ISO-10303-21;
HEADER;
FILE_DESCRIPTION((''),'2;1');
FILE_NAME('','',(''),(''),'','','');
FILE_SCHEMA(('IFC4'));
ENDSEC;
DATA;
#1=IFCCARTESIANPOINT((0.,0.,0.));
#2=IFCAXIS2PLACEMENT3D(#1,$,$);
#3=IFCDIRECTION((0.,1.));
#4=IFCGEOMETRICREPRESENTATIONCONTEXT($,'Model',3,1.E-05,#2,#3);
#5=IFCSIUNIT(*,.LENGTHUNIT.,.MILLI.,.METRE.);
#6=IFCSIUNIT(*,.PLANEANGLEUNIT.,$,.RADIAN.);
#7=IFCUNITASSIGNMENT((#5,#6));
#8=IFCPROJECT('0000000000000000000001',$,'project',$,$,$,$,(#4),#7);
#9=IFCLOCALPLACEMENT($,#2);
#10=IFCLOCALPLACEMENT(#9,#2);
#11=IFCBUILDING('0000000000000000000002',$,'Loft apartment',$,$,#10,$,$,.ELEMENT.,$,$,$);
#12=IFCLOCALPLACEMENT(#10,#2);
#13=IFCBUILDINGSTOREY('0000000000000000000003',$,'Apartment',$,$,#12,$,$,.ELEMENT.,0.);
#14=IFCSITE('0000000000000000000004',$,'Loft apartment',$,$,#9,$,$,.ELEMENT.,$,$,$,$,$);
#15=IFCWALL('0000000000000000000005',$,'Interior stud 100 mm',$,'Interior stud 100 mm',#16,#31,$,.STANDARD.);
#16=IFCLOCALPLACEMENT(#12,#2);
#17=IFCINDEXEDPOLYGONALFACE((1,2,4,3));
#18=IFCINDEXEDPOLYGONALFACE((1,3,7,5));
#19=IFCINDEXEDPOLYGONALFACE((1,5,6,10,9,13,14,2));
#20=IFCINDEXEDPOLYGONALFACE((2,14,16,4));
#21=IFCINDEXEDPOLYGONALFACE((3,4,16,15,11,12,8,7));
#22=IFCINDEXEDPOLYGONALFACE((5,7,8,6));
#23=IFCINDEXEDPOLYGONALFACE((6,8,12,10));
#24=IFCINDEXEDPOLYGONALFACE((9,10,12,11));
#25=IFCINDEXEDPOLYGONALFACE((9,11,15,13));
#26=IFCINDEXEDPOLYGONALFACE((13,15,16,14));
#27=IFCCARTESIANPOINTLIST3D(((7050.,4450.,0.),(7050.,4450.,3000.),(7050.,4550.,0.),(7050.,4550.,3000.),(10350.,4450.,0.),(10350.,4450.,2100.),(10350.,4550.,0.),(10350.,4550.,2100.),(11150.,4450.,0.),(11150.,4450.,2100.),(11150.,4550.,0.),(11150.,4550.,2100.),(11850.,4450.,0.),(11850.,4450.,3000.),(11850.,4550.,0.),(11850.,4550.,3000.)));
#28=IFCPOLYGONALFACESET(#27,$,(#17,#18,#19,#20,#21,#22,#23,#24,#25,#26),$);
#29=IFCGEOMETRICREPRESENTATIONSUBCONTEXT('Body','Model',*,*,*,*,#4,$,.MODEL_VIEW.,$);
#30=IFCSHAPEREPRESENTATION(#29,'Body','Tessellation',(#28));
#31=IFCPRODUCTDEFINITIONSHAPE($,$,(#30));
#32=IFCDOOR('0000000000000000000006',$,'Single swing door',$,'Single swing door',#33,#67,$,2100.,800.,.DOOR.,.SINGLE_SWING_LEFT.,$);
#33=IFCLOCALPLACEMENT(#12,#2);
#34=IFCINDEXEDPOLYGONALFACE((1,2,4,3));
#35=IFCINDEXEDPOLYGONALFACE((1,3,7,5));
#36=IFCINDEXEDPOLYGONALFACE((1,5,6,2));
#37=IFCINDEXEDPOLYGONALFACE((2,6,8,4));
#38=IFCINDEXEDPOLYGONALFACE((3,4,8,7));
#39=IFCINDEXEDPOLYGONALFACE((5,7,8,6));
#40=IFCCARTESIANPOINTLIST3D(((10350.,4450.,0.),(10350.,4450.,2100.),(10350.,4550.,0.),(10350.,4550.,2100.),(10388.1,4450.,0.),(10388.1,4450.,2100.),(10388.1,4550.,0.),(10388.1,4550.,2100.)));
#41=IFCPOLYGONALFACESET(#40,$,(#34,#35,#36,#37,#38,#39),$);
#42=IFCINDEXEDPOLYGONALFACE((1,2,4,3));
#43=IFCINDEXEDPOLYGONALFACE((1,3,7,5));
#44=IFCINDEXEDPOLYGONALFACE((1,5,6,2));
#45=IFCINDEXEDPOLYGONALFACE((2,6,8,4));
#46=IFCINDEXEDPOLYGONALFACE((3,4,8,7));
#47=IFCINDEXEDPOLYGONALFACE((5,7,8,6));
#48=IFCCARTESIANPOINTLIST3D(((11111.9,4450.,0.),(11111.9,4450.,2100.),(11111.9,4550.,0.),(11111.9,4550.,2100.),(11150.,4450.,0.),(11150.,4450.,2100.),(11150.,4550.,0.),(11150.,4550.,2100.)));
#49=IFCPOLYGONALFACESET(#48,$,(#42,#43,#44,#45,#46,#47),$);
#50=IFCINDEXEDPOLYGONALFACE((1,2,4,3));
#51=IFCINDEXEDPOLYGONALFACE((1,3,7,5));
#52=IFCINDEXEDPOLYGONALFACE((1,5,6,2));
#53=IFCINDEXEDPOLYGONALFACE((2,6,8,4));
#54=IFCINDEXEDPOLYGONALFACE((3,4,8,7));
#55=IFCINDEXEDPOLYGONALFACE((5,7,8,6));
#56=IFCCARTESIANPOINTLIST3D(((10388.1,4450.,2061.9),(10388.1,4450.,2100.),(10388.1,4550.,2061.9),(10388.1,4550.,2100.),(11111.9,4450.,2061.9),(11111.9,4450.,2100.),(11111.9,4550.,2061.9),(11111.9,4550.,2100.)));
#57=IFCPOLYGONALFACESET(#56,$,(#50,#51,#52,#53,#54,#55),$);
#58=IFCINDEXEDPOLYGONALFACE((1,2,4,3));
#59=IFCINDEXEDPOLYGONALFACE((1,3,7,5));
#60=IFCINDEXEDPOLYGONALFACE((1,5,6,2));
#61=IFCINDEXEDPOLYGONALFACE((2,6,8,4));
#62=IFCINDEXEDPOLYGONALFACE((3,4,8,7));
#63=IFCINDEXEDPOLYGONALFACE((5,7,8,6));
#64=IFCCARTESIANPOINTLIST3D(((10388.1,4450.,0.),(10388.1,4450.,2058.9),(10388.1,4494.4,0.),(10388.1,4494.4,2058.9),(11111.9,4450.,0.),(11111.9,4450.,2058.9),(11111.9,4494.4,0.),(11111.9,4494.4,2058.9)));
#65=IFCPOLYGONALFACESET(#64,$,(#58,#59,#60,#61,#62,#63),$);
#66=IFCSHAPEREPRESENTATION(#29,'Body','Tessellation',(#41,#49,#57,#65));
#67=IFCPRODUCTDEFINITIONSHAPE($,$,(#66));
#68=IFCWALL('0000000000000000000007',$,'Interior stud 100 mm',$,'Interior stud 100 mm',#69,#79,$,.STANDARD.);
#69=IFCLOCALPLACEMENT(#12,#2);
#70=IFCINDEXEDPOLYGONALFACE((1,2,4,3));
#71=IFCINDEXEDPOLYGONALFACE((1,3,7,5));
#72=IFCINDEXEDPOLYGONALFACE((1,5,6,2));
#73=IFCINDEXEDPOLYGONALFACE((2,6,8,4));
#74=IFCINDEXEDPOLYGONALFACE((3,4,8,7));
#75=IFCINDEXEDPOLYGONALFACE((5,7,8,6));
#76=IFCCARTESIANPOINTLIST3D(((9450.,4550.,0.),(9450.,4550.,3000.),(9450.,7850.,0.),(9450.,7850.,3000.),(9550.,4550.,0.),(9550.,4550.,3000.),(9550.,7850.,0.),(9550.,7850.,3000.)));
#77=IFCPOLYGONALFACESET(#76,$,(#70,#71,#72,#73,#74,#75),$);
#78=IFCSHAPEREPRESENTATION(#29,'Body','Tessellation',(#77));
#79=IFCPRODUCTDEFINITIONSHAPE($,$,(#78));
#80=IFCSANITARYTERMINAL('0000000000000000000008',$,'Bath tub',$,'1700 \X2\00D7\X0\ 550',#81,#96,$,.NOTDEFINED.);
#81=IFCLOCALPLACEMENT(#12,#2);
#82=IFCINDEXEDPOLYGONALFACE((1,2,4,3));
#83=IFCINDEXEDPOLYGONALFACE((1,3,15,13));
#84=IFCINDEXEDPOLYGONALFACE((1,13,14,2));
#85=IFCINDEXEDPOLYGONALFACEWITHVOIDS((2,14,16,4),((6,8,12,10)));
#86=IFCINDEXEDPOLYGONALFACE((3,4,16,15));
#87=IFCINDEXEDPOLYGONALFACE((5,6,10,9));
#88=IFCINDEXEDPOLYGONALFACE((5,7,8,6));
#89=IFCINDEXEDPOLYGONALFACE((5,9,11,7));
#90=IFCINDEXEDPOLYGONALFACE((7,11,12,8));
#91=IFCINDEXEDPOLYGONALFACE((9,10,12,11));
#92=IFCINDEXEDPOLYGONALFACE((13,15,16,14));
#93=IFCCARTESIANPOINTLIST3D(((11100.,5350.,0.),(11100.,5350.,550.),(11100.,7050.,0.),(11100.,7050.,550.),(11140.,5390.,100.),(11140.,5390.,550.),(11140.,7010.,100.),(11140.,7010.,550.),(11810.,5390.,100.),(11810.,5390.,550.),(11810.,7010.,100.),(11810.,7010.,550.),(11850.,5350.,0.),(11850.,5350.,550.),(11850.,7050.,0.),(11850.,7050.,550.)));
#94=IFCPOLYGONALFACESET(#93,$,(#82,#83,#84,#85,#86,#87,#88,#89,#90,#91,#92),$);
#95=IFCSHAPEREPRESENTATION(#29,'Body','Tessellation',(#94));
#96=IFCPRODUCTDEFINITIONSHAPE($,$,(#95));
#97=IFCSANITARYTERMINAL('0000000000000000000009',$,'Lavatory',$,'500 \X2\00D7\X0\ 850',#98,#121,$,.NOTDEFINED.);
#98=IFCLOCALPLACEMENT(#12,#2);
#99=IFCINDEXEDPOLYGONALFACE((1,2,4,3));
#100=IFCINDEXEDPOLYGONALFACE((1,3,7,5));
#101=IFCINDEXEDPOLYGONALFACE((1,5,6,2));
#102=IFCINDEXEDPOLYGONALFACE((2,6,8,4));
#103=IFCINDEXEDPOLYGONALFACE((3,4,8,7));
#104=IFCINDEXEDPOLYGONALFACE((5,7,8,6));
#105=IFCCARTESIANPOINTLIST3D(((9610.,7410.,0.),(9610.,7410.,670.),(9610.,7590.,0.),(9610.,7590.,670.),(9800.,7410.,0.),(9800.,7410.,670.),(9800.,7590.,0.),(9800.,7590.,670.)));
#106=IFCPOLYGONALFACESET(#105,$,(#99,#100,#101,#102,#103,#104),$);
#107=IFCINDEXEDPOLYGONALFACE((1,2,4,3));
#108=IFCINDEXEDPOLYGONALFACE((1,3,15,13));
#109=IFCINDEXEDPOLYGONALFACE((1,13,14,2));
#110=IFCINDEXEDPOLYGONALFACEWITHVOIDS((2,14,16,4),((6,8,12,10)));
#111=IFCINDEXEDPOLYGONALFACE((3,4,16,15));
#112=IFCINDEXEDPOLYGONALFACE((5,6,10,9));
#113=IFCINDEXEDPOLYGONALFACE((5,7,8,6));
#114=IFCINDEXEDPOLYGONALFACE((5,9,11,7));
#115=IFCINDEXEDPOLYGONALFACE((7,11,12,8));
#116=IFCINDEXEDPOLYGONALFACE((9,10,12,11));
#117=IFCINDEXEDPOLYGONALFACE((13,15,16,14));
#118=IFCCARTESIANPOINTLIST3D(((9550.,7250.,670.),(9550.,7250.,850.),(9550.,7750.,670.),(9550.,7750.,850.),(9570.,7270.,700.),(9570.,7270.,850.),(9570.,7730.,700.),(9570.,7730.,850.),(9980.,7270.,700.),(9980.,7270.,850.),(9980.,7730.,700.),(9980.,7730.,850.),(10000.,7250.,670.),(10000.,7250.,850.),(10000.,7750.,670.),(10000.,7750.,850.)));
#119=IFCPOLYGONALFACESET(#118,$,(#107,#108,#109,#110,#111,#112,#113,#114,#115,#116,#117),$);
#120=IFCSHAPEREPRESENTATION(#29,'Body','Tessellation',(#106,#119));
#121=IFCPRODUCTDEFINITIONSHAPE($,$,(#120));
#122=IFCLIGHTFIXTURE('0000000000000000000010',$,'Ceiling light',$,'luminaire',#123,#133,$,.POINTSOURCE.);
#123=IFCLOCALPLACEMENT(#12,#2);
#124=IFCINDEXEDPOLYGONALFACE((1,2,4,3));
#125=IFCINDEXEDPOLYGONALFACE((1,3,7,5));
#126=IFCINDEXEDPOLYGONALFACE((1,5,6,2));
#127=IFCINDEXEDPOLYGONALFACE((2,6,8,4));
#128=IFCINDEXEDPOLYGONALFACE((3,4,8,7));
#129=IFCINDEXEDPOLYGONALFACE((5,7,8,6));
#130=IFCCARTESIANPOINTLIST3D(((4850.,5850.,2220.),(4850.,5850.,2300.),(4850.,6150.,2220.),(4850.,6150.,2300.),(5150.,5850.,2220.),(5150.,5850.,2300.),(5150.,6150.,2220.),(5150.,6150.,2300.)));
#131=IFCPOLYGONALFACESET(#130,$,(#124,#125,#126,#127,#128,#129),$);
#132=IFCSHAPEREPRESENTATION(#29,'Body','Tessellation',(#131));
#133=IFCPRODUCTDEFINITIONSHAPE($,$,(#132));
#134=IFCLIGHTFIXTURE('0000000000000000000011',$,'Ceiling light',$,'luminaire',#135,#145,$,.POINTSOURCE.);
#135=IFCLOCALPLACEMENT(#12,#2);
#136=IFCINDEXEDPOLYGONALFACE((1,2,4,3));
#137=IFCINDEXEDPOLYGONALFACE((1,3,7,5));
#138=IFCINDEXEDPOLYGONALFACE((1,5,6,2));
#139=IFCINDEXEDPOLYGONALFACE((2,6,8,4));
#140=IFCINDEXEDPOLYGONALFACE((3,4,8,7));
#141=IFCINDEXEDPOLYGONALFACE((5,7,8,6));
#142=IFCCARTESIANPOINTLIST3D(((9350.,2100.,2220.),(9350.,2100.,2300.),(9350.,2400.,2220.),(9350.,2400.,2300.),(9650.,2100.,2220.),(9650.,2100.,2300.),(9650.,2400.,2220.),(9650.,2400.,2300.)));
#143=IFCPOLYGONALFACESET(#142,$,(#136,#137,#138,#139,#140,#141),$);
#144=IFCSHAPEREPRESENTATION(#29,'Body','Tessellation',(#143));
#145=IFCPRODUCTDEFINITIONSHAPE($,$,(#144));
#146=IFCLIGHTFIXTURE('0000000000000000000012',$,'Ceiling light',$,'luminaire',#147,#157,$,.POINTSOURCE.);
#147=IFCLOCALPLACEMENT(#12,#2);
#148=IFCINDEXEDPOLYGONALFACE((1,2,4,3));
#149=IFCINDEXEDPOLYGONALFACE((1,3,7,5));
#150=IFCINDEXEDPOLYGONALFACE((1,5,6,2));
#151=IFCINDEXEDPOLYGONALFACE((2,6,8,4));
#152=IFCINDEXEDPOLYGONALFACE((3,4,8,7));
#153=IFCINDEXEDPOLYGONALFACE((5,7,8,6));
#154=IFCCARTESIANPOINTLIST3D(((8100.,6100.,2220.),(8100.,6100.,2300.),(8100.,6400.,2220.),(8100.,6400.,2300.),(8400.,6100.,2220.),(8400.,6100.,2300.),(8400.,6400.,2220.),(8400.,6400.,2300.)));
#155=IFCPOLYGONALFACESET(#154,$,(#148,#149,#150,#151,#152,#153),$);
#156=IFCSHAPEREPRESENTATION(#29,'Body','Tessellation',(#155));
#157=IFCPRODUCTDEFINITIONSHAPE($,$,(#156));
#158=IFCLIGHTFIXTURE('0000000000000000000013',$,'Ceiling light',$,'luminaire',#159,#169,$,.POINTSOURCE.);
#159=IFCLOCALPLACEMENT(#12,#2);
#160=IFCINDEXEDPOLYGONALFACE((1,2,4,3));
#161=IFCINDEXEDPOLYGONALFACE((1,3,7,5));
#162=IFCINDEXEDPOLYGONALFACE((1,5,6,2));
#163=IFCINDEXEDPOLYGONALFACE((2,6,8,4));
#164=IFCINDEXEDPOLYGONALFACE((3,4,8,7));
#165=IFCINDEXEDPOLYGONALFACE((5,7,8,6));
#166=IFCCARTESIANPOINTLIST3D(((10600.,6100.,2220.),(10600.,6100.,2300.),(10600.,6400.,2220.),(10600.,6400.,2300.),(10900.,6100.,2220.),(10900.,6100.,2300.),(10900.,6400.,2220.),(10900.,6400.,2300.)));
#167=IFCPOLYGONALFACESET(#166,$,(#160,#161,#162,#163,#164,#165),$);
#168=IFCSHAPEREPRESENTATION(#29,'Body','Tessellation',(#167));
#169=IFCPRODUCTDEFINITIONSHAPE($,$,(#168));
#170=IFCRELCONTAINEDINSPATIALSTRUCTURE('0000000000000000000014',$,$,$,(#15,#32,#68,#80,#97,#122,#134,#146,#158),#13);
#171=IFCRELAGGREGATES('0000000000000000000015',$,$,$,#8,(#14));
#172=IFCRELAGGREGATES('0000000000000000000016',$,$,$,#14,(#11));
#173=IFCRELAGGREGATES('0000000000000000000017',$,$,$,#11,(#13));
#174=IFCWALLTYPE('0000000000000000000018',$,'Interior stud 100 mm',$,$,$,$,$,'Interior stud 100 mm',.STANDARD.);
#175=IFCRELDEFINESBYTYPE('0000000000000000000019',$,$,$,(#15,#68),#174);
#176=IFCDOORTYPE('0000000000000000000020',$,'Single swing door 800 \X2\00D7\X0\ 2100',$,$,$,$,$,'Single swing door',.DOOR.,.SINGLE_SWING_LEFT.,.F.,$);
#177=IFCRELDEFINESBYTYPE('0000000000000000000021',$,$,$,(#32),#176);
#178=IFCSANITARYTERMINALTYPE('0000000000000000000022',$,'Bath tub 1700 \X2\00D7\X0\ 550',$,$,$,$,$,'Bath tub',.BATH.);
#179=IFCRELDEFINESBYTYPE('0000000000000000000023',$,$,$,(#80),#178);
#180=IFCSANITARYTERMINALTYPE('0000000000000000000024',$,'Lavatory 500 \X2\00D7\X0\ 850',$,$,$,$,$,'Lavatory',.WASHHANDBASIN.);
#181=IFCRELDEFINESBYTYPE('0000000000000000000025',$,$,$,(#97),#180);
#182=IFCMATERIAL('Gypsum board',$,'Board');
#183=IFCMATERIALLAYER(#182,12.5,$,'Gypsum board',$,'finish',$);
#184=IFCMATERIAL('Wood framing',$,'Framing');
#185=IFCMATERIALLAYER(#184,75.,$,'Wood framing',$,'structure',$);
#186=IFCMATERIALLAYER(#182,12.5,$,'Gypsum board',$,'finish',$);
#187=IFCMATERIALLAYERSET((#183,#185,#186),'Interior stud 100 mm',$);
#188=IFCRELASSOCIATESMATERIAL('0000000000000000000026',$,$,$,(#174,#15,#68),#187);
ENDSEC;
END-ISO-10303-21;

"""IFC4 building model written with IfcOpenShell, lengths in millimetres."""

from ifc_helpers import new_model, entity, si_unit, direction, frame, origin, origin_with_axes, place, context, subcontext, project, spatial, polyline, outline, extrude, source, transform, mapped, material, layer, layer_set, layer_usage, type_object, type_shapes, element, fill, save


model = new_model("IFC4")

# Units and contexts
model_context = context("Model", 3, precision=1e-05, world=origin(), true_north=direction((0.0, 1.0)))
body_context = subcontext(model_context, "Body", "Model", "MODEL_VIEW")
ifc_project = project(units=[si_unit("LENGTHUNIT", "METRE", prefix="MILLI"), si_unit("PLANEANGLEUNIT", "RADIAN")], contexts=[model_context])

# Site, building, storey
site_placement = place(None, origin())
site = spatial("IfcSite", under=ifc_project, at=site_placement, Name="Loft apartment", CompositionType="ELEMENT")
building_placement = place(site_placement, origin())
building = spatial("IfcBuilding", under=site, at=building_placement, Name="Loft apartment", CompositionType="ELEMENT")
storey_placement = place(building_placement, origin())
storey = spatial("IfcBuildingStorey", under=building, at=storey_placement, Name="Apartment", CompositionType="ELEMENT", Elevation=0.0)

# Shared definitions
ifc_material_1 = material(Name="Gypsum board", Category="Board")
ifc_layer_1 = layer(ifc_material_1, 12.5, Name="Gypsum board", Category="finish")
ifc_material_2 = material(Name="Wood framing", Category="Framing")
ifc_layer_2 = layer(ifc_material_2, 75.0, Name="Wood framing", Category="structure")
ifc_layer_3 = layer(ifc_material_1, 12.5, Name="Gypsum board", Category="finish")
ifc_layer_set_1 = layer_set([ifc_layer_1, ifc_layer_2, ifc_layer_3], Name="Interior stud 100 mm")
wall_type_1 = type_object("IfcWallType", Name="Interior stud 100 mm", ElementType="Interior stud 100 mm", PredefinedType="STANDARD", material=ifc_layer_set_1)

# Wall, opening, door
ifc_layer_usage_1 = layer_usage(ifc_layer_set_1, "AXIS2", "NEGATIVE", 50.0)
wall_1_placement = place(storey_placement, frame((7000.0, 4500.0, 0.0), z_axis=(0.0, 0.0, 1.0), x_axis=(1.0, 0.0, 0.0)))
wall_1 = element("IfcWall", 1, at=wall_1_placement, inside=storey, type_object=wall_type_1, material=ifc_layer_usage_1, Name="Interior stud 100 mm", ObjectType="Interior stud 100 mm", PredefinedType="STANDARD", context=body_context, shape_type="SweptSolid", body=[
    extrude(outline(polyline([(50.0, -50.0), (4850.0, -50.0), (4850.0, 50.0), (50.0, 50.0), (50.0, -50.0)])), origin(), (0.0, 0.0, 1.0), 3000.0),
])
opening_1_placement = place(wall_1_placement, frame((3350.0, 0.0, 0.0), z_axis=(0.0, 0.0, 1.0), x_axis=(1.0, 0.0, 0.0)))
opening_1 = element("IfcOpeningElement", 2, at=opening_1_placement, cuts=wall_1, PredefinedType="OPENING", context=body_context, shape_type="SweptSolid", body=[
    extrude(outline(polyline([(0.0, -60.0), (800.0, -60.0), (800.0, 60.0), (0.0, 60.0), (0.0, -60.0)])), origin(), (0.0, 0.0, 1.0), 2100.0),
])
door_type_1 = type_object("IfcDoorType", Name="Single swing door 800 × 2100", ElementType="Single swing door", OperationType="SINGLE_SWING_LEFT", ParameterTakesPrecedence=False, PredefinedType="DOOR")
door_1_placement = place(opening_1_placement, origin_with_axes())
door_1 = element("IfcDoor", 3, at=door_1_placement, inside=storey, type_object=door_type_1, Name="Single swing door", ObjectType="Single swing door", OperationType="SINGLE_SWING_LEFT", OverallHeight=2100.0, OverallWidth=800.0, PredefinedType="DOOR", context=body_context, shape_type="SweptSolid", body=[
    extrude(outline(polyline([(0.0, -50.0), (38.1, -50.0), (38.1, 50.0), (0.0, 50.0), (0.0, -50.0)])), origin(), (0.0, 0.0, 1.0), 2100.0),
    extrude(outline(polyline([(761.9, -50.0), (800.0, -50.0), (800.0, 50.0), (761.9, 50.0), (761.9, -50.0)])), origin(), (0.0, 0.0, 1.0), 2100.0),
    extrude(outline(polyline([(38.1, -50.0), (761.9, -50.0), (761.9, 50.0), (38.1, 50.0), (38.1, -50.0)])), frame((0.0, 0.0, 2061.9)), (0.0, 0.0, 1.0), 38.1),
    extrude(outline(polyline([(38.1, -50.0), (761.9, -50.0), (761.9, -5.5), (38.1, -5.5), (38.1, -50.0)])), origin(), (0.0, 0.0, 1.0), 2058.9),
])
fill(opening_1, door_1)

# Wall
ifc_layer_usage_2 = layer_usage(ifc_layer_set_1, "AXIS2", "NEGATIVE", 50.0)
wall_2_placement = place(storey_placement, frame((9500.0, 4500.0, 0.0), z_axis=(0.0, 0.0, 1.0), x_axis=(0.0, 1.0, 0.0)))
element("IfcWall", 4, at=wall_2_placement, inside=storey, type_object=wall_type_1, material=ifc_layer_usage_2, Name="Interior stud 100 mm", ObjectType="Interior stud 100 mm", PredefinedType="STANDARD", context=body_context, shape_type="SweptSolid", body=[
    extrude(outline(polyline([(50.0, -50.0), (3350.0, -50.0), (3350.0, 50.0), (50.0, 50.0), (50.0, -50.0)])), origin(), (0.0, 0.0, 1.0), 3000.0),
])

# Sanitary terminals
sanitary_terminal_type_1 = type_object("IfcSanitaryTerminalType", Name="Bath tub 1700 × 550", ElementType="Bath tub", PredefinedType="BATH")
cartesian_point_1 = entity("IfcCartesianPoint", [-850.0, 0.0])
cartesian_point_2 = entity("IfcCartesianPoint", [-810.0, 40.0])
shared_shape_1 = source(origin(), body_context, "Body", "SolidModel", [
    entity("IfcCsgSolid", entity("IfcBooleanResult", "DIFFERENCE", entity("IfcExtrudedAreaSolid", entity("IfcArbitraryClosedProfileDef", "AREA", None, entity("IfcPolyline", [cartesian_point_1, entity("IfcCartesianPoint", [850.0, 0.0]), entity("IfcCartesianPoint", [850.0, 750.0]), entity("IfcCartesianPoint", [-850.0, 750.0]), cartesian_point_1])), entity("IfcAxis2Placement3D", entity("IfcCartesianPoint", [0.0, 0.0, 0.0])), entity("IfcDirection", [0.0, 0.0, 1.0]), 550.0), entity("IfcExtrudedAreaSolid", entity("IfcArbitraryClosedProfileDef", "AREA", None, entity("IfcPolyline", [cartesian_point_2, entity("IfcCartesianPoint", [810.0, 40.0]), entity("IfcCartesianPoint", [810.0, 710.0]), entity("IfcCartesianPoint", [-810.0, 710.0]), cartesian_point_2])), entity("IfcAxis2Placement3D", entity("IfcCartesianPoint", [0.0, 0.0, 100.0])), entity("IfcDirection", [0.0, 0.0, 1.0]), 451.0))),
])
type_shapes(sanitary_terminal_type_1, [shared_shape_1])
sanitary_terminal_1_placement = place(storey_placement, frame((11100.0, 6200.0, 0.0), z_axis=(0.0, 0.0, 1.0), x_axis=(0.0, -1.0, 0.0)))
element("IfcSanitaryTerminal", 5, at=sanitary_terminal_1_placement, inside=storey, type_object=sanitary_terminal_type_1, Name="Bath tub", ObjectType="1700 × 550", PredefinedType="NOTDEFINED", context=body_context, shape_type="MappedRepresentation", body=[
    mapped(shared_shape_1, transform((0.0, 0.0, 0.0))),
])
sanitary_terminal_type_2 = type_object("IfcSanitaryTerminalType", Name="Lavatory 500 × 850", ElementType="Lavatory", PredefinedType="WASHHANDBASIN")
cartesian_point_3 = entity("IfcCartesianPoint", [-250.0, 0.0])
cartesian_point_4 = entity("IfcCartesianPoint", [-230.0, 20.0])
shared_shape_2 = source(origin(), body_context, "Body", "SolidModel", [
    extrude(outline(polyline([(-90.0, 200.0), (90.0, 200.0), (90.0, 390.0), (-90.0, 390.0), (-90.0, 200.0)])), origin(), (0.0, 0.0, 1.0), 670.0),
    entity("IfcCsgSolid", entity("IfcBooleanResult", "DIFFERENCE", entity("IfcExtrudedAreaSolid", entity("IfcArbitraryClosedProfileDef", "AREA", None, entity("IfcPolyline", [cartesian_point_3, entity("IfcCartesianPoint", [250.0, 0.0]), entity("IfcCartesianPoint", [250.0, 450.0]), entity("IfcCartesianPoint", [-250.0, 450.0]), cartesian_point_3])), entity("IfcAxis2Placement3D", entity("IfcCartesianPoint", [0.0, 0.0, 670.0])), entity("IfcDirection", [0.0, 0.0, 1.0]), 180.0), entity("IfcExtrudedAreaSolid", entity("IfcArbitraryClosedProfileDef", "AREA", None, entity("IfcPolyline", [cartesian_point_4, entity("IfcCartesianPoint", [230.0, 20.0]), entity("IfcCartesianPoint", [230.0, 430.0]), entity("IfcCartesianPoint", [-230.0, 430.0]), cartesian_point_4])), entity("IfcAxis2Placement3D", entity("IfcCartesianPoint", [0.0, 0.0, 700.0])), entity("IfcDirection", [0.0, 0.0, 1.0]), 151.0))),
])
type_shapes(sanitary_terminal_type_2, [shared_shape_2])
sanitary_terminal_2_placement = place(storey_placement, frame((10000.0, 7500.0, 0.0), z_axis=(0.0, 0.0, 1.0), x_axis=(0.0, 1.0, 0.0)))
element("IfcSanitaryTerminal", 6, at=sanitary_terminal_2_placement, inside=storey, type_object=sanitary_terminal_type_2, Name="Lavatory", ObjectType="500 × 850", PredefinedType="NOTDEFINED", context=body_context, shape_type="MappedRepresentation", body=[
    mapped(shared_shape_2, transform((0.0, 0.0, 0.0))),
])

# Light fixtures
for number, where, z_axis, x_axis, name in (
    (7, (5000.0, 6000.0, 0.0), (0.0, 0.0, 1.0), (0.0, -1.0, 0.0), "Ceiling light"),
    (8, (9500.0, 2250.0, 0.0), (0.0, 0.0, 1.0), (0.0, -1.0, 0.0), "Ceiling light"),
    (9, (8250.0, 6250.0, 0.0), (0.0, 0.0, 1.0), (0.0, -1.0, 0.0), "Ceiling light"),
    (10, (10750.0, 6250.0, 0.0), (0.0, 0.0, 1.0), (0.0, -1.0, 0.0), "Ceiling light"),
):
    element("IfcLightFixture", number, at=place(storey_placement, frame(where, z_axis=z_axis, x_axis=x_axis)), inside=storey, Name=name, ObjectType="luminaire", PredefinedType="POINTSOURCE", context=body_context, shape_type="SweptSolid", body=[
        extrude(outline(polyline([(-150.0, -150.0), (150.0, -150.0), (150.0, 150.0), (-150.0, 150.0), (-150.0, -150.0)])), frame((0.0, 0.0, 2220.0)), (0.0, 0.0, 1.0), 80.0),
    ])

save(model, "model.ifc")
